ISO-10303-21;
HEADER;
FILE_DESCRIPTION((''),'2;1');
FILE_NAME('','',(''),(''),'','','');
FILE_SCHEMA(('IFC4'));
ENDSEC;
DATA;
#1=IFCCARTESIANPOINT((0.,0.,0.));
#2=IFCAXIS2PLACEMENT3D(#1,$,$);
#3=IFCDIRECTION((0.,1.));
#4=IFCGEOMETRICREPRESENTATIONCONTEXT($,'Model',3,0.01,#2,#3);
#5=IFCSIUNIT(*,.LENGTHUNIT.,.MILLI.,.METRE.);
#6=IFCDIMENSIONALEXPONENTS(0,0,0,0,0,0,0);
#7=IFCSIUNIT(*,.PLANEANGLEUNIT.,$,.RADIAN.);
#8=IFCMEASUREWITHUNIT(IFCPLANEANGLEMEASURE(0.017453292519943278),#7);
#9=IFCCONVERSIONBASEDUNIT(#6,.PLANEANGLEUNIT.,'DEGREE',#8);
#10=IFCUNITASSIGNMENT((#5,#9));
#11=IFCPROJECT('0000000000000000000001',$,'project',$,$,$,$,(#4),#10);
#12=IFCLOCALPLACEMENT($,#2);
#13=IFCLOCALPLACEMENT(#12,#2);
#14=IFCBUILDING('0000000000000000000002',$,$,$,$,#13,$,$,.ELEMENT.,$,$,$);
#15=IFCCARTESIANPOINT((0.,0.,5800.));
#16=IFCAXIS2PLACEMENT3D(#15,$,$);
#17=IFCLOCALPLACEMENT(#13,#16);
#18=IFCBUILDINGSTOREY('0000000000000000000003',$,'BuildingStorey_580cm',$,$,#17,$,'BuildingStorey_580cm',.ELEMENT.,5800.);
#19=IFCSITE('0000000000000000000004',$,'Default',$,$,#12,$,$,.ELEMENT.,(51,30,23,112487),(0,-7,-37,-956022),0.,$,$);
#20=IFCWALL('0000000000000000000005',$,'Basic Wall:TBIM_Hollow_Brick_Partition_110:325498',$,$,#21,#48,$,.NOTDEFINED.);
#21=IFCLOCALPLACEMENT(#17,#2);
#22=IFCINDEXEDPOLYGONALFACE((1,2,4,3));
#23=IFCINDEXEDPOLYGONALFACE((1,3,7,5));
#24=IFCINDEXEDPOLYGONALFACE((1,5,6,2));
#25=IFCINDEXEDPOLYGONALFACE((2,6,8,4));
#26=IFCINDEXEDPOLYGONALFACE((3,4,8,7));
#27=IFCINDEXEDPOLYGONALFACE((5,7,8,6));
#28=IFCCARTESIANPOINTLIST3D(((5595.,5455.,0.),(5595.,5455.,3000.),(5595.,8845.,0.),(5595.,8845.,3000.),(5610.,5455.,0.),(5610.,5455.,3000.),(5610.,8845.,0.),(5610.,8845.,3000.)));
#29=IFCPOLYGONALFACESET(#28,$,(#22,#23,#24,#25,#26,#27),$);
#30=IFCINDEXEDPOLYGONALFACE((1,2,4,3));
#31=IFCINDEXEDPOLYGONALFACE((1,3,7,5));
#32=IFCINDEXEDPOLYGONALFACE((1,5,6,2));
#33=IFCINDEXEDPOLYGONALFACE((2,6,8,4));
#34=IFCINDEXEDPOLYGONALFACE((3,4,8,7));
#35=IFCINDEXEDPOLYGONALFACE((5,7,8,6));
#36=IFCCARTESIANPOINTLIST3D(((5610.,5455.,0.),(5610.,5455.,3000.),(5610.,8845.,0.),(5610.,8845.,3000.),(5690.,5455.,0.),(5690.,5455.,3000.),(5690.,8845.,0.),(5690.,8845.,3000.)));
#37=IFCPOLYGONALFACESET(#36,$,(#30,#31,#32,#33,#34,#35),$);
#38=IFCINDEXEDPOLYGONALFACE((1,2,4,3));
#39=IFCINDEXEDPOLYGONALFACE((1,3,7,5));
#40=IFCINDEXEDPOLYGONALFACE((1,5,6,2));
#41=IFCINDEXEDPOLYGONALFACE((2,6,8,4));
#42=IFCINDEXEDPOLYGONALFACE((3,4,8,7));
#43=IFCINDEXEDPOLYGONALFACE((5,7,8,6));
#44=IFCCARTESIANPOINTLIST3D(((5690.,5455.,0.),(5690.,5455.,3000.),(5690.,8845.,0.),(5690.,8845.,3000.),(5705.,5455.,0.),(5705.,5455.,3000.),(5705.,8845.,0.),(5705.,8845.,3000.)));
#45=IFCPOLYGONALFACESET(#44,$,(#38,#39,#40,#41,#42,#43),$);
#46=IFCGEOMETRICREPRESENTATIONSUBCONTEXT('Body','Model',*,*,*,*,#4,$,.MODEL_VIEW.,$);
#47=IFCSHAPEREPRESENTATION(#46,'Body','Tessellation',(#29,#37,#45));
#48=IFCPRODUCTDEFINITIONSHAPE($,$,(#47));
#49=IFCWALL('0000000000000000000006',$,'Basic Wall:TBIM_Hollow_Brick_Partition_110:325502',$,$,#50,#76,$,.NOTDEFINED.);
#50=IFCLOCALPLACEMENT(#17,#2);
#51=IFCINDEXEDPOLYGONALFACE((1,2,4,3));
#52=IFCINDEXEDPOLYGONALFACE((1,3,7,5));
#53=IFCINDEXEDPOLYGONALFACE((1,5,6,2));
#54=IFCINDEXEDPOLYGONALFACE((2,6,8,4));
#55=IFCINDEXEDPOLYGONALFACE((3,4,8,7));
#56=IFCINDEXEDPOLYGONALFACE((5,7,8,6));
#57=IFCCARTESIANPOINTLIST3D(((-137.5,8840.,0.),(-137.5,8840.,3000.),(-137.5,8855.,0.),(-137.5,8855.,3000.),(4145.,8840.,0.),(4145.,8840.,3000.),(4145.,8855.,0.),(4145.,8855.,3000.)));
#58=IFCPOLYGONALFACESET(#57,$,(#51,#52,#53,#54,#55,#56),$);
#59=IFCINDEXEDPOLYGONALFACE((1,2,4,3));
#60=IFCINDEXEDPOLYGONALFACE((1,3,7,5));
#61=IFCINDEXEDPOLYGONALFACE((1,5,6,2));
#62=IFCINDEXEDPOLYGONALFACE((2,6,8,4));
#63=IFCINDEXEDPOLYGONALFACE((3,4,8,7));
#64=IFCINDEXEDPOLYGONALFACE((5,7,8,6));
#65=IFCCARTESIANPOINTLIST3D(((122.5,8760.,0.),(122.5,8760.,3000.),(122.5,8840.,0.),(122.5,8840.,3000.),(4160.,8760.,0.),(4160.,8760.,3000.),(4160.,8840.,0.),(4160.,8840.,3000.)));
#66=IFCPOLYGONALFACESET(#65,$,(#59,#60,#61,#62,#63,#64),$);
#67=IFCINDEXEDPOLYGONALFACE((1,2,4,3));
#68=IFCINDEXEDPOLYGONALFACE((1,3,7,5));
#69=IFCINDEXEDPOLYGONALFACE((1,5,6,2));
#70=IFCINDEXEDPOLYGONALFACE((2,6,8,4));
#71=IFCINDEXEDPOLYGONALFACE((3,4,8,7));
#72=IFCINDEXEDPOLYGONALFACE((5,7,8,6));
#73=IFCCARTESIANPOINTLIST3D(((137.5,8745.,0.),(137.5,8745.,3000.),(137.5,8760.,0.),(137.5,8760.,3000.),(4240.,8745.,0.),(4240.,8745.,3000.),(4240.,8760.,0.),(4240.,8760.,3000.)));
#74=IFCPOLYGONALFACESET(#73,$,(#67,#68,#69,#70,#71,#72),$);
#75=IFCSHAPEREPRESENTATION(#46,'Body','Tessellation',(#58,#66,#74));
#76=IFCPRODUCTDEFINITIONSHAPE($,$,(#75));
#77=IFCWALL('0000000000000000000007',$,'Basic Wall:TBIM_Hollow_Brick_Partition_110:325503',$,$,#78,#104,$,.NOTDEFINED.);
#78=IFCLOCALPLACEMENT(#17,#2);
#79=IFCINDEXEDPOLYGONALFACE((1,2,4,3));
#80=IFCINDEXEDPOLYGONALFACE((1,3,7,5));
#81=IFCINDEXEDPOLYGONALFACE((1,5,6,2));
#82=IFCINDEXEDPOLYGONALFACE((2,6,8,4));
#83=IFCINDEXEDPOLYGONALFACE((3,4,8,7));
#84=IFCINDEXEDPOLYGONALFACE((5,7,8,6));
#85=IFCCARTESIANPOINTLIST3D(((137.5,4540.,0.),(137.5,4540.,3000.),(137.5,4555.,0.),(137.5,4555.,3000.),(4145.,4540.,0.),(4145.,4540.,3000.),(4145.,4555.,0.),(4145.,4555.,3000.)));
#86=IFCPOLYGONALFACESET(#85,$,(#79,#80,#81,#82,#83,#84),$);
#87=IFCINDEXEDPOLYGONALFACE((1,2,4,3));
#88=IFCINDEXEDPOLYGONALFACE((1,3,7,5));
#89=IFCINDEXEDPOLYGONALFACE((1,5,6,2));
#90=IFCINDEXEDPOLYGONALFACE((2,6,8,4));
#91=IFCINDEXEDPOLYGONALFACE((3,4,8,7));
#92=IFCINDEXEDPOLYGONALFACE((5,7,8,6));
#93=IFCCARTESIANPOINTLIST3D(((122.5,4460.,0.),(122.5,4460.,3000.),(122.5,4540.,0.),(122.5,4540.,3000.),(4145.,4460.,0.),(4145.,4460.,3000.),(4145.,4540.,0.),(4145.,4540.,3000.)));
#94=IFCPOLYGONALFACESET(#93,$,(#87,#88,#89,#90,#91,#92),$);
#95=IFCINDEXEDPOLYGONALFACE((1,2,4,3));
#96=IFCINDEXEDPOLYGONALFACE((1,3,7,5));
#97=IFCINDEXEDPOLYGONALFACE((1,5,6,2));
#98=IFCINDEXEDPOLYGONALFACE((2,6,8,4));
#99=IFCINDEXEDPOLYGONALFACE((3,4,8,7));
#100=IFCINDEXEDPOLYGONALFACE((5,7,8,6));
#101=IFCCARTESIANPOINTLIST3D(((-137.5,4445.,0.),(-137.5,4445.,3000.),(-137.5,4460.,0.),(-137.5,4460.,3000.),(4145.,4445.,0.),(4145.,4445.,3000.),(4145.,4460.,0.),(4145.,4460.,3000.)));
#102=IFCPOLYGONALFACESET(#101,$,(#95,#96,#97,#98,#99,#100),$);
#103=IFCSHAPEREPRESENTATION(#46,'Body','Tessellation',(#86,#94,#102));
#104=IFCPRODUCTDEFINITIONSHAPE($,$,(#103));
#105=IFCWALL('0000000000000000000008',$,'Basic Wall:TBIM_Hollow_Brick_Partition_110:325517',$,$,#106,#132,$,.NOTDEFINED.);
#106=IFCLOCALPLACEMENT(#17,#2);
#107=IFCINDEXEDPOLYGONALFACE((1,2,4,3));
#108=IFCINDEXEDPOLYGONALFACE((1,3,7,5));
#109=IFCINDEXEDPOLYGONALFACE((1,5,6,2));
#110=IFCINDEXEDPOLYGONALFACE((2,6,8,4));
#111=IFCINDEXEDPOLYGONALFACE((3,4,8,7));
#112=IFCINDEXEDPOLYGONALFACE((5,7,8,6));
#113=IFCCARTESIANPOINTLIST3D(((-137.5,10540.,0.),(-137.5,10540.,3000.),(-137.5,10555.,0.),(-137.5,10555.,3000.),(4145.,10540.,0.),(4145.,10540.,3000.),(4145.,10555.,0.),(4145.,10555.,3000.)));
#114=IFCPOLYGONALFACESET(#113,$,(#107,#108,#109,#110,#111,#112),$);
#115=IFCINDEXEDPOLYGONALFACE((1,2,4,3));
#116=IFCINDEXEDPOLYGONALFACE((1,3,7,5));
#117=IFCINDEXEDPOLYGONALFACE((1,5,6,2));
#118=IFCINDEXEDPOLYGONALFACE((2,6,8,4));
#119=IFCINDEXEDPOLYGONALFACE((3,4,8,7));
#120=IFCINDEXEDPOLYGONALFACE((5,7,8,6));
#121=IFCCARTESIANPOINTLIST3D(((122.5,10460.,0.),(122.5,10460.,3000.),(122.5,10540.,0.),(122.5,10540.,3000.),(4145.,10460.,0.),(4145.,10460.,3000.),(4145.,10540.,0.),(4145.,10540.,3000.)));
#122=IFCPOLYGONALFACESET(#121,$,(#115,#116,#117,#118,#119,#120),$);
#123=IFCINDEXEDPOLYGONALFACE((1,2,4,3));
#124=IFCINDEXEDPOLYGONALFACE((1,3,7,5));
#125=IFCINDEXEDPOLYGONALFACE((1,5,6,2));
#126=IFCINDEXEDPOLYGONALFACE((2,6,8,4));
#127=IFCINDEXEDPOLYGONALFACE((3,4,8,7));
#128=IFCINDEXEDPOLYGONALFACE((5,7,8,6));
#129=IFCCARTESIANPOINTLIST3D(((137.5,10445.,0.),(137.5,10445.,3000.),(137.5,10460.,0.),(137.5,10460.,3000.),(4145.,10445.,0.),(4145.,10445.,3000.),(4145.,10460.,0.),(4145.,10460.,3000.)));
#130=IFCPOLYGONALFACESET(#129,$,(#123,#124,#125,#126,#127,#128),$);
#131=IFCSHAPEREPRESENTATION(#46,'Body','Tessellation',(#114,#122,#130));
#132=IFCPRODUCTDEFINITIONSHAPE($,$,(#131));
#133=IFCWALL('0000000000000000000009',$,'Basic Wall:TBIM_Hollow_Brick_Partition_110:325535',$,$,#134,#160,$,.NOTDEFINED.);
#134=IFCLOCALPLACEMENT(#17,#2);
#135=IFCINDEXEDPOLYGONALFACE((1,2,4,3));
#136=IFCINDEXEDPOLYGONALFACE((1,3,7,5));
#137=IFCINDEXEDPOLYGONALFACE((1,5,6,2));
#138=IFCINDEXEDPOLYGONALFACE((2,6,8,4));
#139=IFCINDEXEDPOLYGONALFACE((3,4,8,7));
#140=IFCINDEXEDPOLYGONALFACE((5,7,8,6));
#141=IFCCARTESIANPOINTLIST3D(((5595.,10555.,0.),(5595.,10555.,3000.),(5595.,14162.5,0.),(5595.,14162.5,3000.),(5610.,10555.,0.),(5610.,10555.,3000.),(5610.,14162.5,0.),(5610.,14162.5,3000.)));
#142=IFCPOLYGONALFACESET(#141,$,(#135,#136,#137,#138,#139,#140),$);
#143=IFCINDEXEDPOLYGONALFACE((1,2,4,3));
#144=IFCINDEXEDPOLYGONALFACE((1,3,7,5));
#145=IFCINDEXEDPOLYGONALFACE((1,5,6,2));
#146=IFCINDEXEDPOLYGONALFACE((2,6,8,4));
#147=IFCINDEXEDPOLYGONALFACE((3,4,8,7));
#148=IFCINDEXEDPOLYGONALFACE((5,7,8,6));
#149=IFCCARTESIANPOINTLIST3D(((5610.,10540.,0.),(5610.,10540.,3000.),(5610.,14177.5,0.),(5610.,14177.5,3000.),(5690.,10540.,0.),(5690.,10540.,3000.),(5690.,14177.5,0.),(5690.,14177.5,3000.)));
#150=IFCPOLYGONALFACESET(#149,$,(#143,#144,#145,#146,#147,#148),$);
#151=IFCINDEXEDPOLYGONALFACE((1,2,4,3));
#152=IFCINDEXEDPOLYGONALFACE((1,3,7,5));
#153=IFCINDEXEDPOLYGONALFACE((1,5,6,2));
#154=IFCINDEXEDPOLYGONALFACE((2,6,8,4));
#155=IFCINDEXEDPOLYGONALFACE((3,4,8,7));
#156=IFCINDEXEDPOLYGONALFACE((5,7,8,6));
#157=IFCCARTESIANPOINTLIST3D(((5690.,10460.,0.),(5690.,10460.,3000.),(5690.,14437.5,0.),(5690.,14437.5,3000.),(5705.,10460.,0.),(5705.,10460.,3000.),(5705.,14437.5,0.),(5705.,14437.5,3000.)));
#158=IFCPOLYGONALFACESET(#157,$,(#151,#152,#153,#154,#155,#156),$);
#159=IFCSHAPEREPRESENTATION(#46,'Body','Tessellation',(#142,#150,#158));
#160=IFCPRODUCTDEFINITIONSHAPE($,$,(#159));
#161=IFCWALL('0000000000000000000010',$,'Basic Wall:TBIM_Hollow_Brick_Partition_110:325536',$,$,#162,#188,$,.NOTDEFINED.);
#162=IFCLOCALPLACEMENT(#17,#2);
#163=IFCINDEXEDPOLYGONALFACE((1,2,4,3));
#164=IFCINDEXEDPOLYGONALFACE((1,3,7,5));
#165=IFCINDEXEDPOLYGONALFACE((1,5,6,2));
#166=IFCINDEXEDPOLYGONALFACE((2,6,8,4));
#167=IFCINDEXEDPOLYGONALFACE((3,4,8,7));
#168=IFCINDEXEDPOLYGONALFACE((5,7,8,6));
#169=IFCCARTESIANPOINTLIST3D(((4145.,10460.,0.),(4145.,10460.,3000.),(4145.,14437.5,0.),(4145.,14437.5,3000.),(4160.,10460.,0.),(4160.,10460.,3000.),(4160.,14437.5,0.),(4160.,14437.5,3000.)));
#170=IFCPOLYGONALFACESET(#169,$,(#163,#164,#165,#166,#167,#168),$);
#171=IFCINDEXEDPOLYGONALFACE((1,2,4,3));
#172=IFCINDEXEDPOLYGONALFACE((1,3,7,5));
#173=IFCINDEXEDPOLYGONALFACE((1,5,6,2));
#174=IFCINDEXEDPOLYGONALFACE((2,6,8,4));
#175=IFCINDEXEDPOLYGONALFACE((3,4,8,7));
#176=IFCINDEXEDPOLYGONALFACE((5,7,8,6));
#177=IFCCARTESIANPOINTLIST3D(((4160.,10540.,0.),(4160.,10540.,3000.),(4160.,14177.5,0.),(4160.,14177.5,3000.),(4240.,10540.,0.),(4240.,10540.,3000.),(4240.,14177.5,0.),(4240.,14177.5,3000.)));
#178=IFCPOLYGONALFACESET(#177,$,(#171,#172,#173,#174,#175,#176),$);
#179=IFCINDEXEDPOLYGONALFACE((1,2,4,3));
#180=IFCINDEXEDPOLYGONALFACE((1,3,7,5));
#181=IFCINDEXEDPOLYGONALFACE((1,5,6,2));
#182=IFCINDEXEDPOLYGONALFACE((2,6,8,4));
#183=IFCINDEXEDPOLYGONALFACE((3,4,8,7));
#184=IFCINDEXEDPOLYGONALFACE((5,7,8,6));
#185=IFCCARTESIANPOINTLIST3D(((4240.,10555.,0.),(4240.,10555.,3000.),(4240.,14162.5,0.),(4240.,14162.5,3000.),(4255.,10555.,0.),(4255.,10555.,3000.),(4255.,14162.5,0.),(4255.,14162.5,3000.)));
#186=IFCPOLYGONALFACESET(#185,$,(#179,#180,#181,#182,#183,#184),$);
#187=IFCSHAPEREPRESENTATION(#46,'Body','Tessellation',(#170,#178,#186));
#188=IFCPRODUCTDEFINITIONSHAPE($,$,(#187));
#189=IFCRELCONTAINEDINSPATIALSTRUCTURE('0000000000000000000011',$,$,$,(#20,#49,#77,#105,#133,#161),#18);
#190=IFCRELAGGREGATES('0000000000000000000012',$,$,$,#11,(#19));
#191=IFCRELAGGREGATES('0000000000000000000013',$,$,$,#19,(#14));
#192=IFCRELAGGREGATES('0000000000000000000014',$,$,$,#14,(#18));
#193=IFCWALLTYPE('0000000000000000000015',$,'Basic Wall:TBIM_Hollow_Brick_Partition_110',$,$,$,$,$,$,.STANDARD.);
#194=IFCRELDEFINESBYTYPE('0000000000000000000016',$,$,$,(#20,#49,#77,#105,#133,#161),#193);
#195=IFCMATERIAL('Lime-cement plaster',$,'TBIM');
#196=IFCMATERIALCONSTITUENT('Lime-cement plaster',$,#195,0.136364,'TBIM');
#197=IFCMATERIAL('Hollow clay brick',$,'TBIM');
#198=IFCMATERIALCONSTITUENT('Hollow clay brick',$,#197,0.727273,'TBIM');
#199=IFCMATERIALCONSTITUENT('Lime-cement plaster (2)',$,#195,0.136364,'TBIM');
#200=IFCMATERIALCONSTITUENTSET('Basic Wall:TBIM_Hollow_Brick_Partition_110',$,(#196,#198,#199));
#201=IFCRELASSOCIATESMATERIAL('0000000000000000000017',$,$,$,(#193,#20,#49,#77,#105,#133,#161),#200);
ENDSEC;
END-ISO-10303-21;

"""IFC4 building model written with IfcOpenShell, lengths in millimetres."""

from ifc_helpers import new_model, entity, si_unit, converted_unit, direction, frame, origin, place, context, subcontext, project, spatial, indexed_curve, outline, extrude, material, constituent, constituent_set, type_object, element, save


model = new_model("IFC4")

# Units and contexts
model_context = context("Model", 3, precision=0.01, world=origin(), true_north=direction((0.0, 1.0)))
body_context = subcontext(model_context, "Body", "Model", "MODEL_VIEW")
ifc_project = project(units=[si_unit("LENGTHUNIT", "METRE", prefix="MILLI"), converted_unit("PLANEANGLEUNIT", "DEGREE", entity("IfcPlaneAngleMeasure", 0.017453292519943278), si_unit("PLANEANGLEUNIT", "RADIAN"), dimensions=[0, 0, 0, 0, 0, 0, 0])], contexts=[model_context])

# Site, building, storey
site_placement = place(None, origin())
site = spatial("IfcSite", under=ifc_project, at=site_placement, Name="Default", CompositionType="ELEMENT", RefLatitude=(51, 30, 23, 112487), RefLongitude=(0, -7, -37, -956022), RefElevation=0.0)
building_placement = place(site_placement, origin())
building = spatial("IfcBuilding", under=site, at=building_placement, CompositionType="ELEMENT")
storey_placement = place(building_placement, frame((0.0, 0.0, 5800.0)))
storey = spatial("IfcBuildingStorey", under=building, at=storey_placement, Name="BuildingStorey_580cm", LongName="BuildingStorey_580cm", CompositionType="ELEMENT", Elevation=5800.0)

# Shared definitions
ifc_material_1 = material(Name="Lime-cement plaster", Category="TBIM")

# Shared definitions
ifc_material_2 = material(Name="Hollow clay brick", Category="TBIM")

# Shared definitions
ifc_constituent_1 = constituent(ifc_material_1, Name="Lime-cement plaster", Category="TBIM", fraction=0.136364)
ifc_constituent_2 = constituent(ifc_material_2, Name="Hollow clay brick", Category="TBIM", fraction=0.727273)
ifc_constituent_3 = constituent(ifc_material_1, Name="Lime-cement plaster (2)", Category="TBIM", fraction=0.136364)
ifc_constituent_set_1 = constituent_set(constituents=[ifc_constituent_1, ifc_constituent_2, ifc_constituent_3], Name="Basic Wall:TBIM_Hollow_Brick_Partition_110")
wall_type_1 = type_object("IfcWallType", Name="Basic Wall:TBIM_Hollow_Brick_Partition_110", PredefinedType="STANDARD", material=ifc_constituent_set_1)

# Wall
wall_1_placement = place(storey_placement, frame((5650.0, 5455.0, 0.0), z_axis=(0.0, 0.0, 1.0), x_axis=(0.0, 1.0, 0.0)))
element("IfcWall", 1, at=wall_1_placement, inside=storey, type_object=wall_type_1, material=ifc_constituent_set_1, Name="Basic Wall:TBIM_Hollow_Brick_Partition_110:325498", PredefinedType="NOTDEFINED", context=body_context, shape_type="SweptSolid", body=[
    extrude(outline(indexed_curve([(-7.5, -1695.0), (7.5, -1695.0), (7.5, 1695.0), (-7.5, 1695.0), (-7.5, -1695.0)], self_intersect=False)), frame((1695.0, 47.5, 0.0), z_axis=(0.0, 0.0, 1.0), x_axis=(0.0, -1.0, 0.0)), (0.0, 0.0, 1.0), 3000.0),
    extrude(outline(indexed_curve([(-1695.0, -40.0), (1695.0, -40.0), (1695.0, 40.0), (-1695.0, 40.0), (-1695.0, -40.0)], self_intersect=False)), frame((1695.0, 0.0, 0.0)), (0.0, 0.0, 1.0), 3000.0),
    extrude(outline(indexed_curve([(-7.5, -1695.0), (7.5, -1695.0), (7.5, 1695.0), (-7.5, 1695.0), (-7.5, -1695.0)], self_intersect=False)), frame((1695.0, -47.5, 0.0), z_axis=(0.0, 0.0, 1.0), x_axis=(0.0, 1.0, 0.0)), (0.0, 0.0, 1.0), 3000.0),
])

# Walls
wall_2_placement = place(storey_placement, frame((137.5, 8800.0, 0.0)))
element("IfcWall", 2, at=wall_2_placement, inside=storey, type_object=wall_type_1, material=ifc_constituent_set_1, Name="Basic Wall:TBIM_Hollow_Brick_Partition_110:325502", PredefinedType="NOTDEFINED", context=body_context, shape_type="SweptSolid", body=[
    extrude(outline(indexed_curve([(-7.5, -2141.2), (7.5, -2141.2), (7.5, 2141.2), (-7.5, 2141.2), (-7.5, -2141.2)], self_intersect=False)), frame((1866.2, 47.5, 0.0), z_axis=(0.0, 0.0, 1.0), x_axis=(0.0, -1.0, 0.0)), (0.0, 0.0, 1.0), 3000.0),
    extrude(outline(indexed_curve([(-2018.7, -40.0), (2018.7, -40.0), (2018.7, 40.0), (-2018.7, 40.0), (-2018.7, -40.0)], self_intersect=False)), frame((2003.7, 0.0, 0.0)), (0.0, 0.0, 1.0), 3000.0),
    extrude(outline(indexed_curve([(-7.5, -2051.2), (7.5, -2051.2), (7.5, 2051.2), (-7.5, 2051.2), (-7.5, -2051.2)], self_intersect=False)), frame((2051.2, -47.5, 0.0), z_axis=(0.0, 0.0, 1.0), x_axis=(0.0, 1.0, 0.0)), (0.0, 0.0, 1.0), 3000.0),
])
wall_3_placement = place(storey_placement, frame((137.5, 4500.0, 0.0)))
element("IfcWall", 3, at=wall_3_placement, inside=storey, type_object=wall_type_1, material=ifc_constituent_set_1, Name="Basic Wall:TBIM_Hollow_Brick_Partition_110:325503", PredefinedType="NOTDEFINED", context=body_context, shape_type="SweptSolid", body=[
    extrude(outline(indexed_curve([(-7.5, -2003.7), (7.5, -2003.7), (7.5, 2003.7), (-7.5, 2003.7), (-7.5, -2003.7)], self_intersect=False)), frame((2003.7, 47.5, 0.0), z_axis=(0.0, 0.0, 1.0), x_axis=(0.0, -1.0, 0.0)), (0.0, 0.0, 1.0), 3000.0),
    extrude(outline(indexed_curve([(-2011.2, -40.0), (2011.2, -40.0), (2011.2, 40.0), (-2011.2, 40.0), (-2011.2, -40.0)], self_intersect=False)), frame((1996.2, 0.0, 0.0)), (0.0, 0.0, 1.0), 3000.0),
    extrude(outline(indexed_curve([(-7.5, -2141.2), (7.5, -2141.2), (7.5, 2141.2), (-7.5, 2141.2), (-7.5, -2141.2)], self_intersect=False)), frame((1866.2, -47.5, 0.0), z_axis=(0.0, 0.0, 1.0), x_axis=(0.0, 1.0, 0.0)), (0.0, 0.0, 1.0), 3000.0),
])
wall_4_placement = place(storey_placement, frame((137.5, 10500.0, 0.0)))
element("IfcWall", 4, at=wall_4_placement, inside=storey, type_object=wall_type_1, material=ifc_constituent_set_1, Name="Basic Wall:TBIM_Hollow_Brick_Partition_110:325517", PredefinedType="NOTDEFINED", context=body_context, shape_type="SweptSolid", body=[
    extrude(outline(indexed_curve([(-7.5, -2141.2), (7.5, -2141.2), (7.5, 2141.2), (-7.5, 2141.2), (-7.5, -2141.2)], self_intersect=False)), frame((1866.2, 47.5, 0.0), z_axis=(0.0, 0.0, 1.0), x_axis=(0.0, -1.0, 0.0)), (0.0, 0.0, 1.0), 3000.0),
    extrude(outline(indexed_curve([(-2011.2, -40.0), (2011.2, -40.0), (2011.2, 40.0), (-2011.2, 40.0), (-2011.2, -40.0)], self_intersect=False)), frame((1996.2, 0.0, 0.0)), (0.0, 0.0, 1.0), 3000.0),
    extrude(outline(indexed_curve([(-7.5, -2003.7), (7.5, -2003.7), (7.5, 2003.7), (-7.5, 2003.7), (-7.5, -2003.7)], self_intersect=False)), frame((2003.7, -47.5, 0.0), z_axis=(0.0, 0.0, 1.0), x_axis=(0.0, 1.0, 0.0)), (0.0, 0.0, 1.0), 3000.0),
])
wall_5_placement = place(storey_placement, frame((5650.0, 10555.0, 0.0), z_axis=(0.0, 0.0, 1.0), x_axis=(0.0, 1.0, 0.0)))
element("IfcWall", 5, at=wall_5_placement, inside=storey, type_object=wall_type_1, material=ifc_constituent_set_1, Name="Basic Wall:TBIM_Hollow_Brick_Partition_110:325535", PredefinedType="NOTDEFINED", context=body_context, shape_type="SweptSolid", body=[
    extrude(outline(indexed_curve([(-7.5, -1803.7), (7.5, -1803.7), (7.5, 1803.8), (-7.5, 1803.8), (-7.5, -1803.7)], self_intersect=False)), frame((1803.7, 47.5, 0.0), z_axis=(0.0, 0.0, 1.0), x_axis=(0.0, -1.0, 0.0)), (0.0, 0.0, 1.0), 3000.0),
    extrude(outline(indexed_curve([(-1818.8, -40.0), (1818.8, -40.0), (1818.8, 40.0), (-1818.8, 40.0), (-1818.8, -40.0)], self_intersect=False)), frame((1803.7, 0.0, 0.0)), (0.0, 0.0, 1.0), 3000.0),
    extrude(outline(indexed_curve([(-7.5, -1988.8), (7.5, -1988.8), (7.5, 1988.8), (-7.5, 1988.8), (-7.5, -1988.8)], self_intersect=False)), frame((1893.8, -47.5, 0.0), z_axis=(0.0, 0.0, 1.0), x_axis=(0.0, 1.0, 0.0)), (0.0, 0.0, 1.0), 3000.0),
])
wall_6_placement = place(storey_placement, frame((4200.0, 10555.0, 0.0), z_axis=(0.0, 0.0, 1.0), x_axis=(0.0, 1.0, 0.0)))
element("IfcWall", 6, at=wall_6_placement, inside=storey, type_object=wall_type_1, material=ifc_constituent_set_1, Name="Basic Wall:TBIM_Hollow_Brick_Partition_110:325536", PredefinedType="NOTDEFINED", context=body_context, shape_type="SweptSolid", body=[
    extrude(outline(indexed_curve([(-7.5, -1988.8), (7.5, -1988.8), (7.5, 1988.8), (-7.5, 1988.8), (-7.5, -1988.8)], self_intersect=False)), frame((1893.8, 47.5, 0.0), z_axis=(0.0, 0.0, 1.0), x_axis=(0.0, -1.0, 0.0)), (0.0, 0.0, 1.0), 3000.0),
    extrude(outline(indexed_curve([(-1818.8, -40.0), (1818.8, -40.0), (1818.8, 40.0), (-1818.8, 40.0), (-1818.8, -40.0)], self_intersect=False)), frame((1803.7, 0.0, 0.0)), (0.0, 0.0, 1.0), 3000.0),
    extrude(outline(indexed_curve([(-7.5, -1803.8), (7.5, -1803.8), (7.5, 1803.7), (-7.5, 1803.7), (-7.5, -1803.8)], self_intersect=False)), frame((1803.7, -47.5, 0.0), z_axis=(0.0, 0.0, 1.0), x_axis=(0.0, 1.0, 0.0)), (0.0, 0.0, 1.0), 3000.0),
])

save(model, "model.ifc")
